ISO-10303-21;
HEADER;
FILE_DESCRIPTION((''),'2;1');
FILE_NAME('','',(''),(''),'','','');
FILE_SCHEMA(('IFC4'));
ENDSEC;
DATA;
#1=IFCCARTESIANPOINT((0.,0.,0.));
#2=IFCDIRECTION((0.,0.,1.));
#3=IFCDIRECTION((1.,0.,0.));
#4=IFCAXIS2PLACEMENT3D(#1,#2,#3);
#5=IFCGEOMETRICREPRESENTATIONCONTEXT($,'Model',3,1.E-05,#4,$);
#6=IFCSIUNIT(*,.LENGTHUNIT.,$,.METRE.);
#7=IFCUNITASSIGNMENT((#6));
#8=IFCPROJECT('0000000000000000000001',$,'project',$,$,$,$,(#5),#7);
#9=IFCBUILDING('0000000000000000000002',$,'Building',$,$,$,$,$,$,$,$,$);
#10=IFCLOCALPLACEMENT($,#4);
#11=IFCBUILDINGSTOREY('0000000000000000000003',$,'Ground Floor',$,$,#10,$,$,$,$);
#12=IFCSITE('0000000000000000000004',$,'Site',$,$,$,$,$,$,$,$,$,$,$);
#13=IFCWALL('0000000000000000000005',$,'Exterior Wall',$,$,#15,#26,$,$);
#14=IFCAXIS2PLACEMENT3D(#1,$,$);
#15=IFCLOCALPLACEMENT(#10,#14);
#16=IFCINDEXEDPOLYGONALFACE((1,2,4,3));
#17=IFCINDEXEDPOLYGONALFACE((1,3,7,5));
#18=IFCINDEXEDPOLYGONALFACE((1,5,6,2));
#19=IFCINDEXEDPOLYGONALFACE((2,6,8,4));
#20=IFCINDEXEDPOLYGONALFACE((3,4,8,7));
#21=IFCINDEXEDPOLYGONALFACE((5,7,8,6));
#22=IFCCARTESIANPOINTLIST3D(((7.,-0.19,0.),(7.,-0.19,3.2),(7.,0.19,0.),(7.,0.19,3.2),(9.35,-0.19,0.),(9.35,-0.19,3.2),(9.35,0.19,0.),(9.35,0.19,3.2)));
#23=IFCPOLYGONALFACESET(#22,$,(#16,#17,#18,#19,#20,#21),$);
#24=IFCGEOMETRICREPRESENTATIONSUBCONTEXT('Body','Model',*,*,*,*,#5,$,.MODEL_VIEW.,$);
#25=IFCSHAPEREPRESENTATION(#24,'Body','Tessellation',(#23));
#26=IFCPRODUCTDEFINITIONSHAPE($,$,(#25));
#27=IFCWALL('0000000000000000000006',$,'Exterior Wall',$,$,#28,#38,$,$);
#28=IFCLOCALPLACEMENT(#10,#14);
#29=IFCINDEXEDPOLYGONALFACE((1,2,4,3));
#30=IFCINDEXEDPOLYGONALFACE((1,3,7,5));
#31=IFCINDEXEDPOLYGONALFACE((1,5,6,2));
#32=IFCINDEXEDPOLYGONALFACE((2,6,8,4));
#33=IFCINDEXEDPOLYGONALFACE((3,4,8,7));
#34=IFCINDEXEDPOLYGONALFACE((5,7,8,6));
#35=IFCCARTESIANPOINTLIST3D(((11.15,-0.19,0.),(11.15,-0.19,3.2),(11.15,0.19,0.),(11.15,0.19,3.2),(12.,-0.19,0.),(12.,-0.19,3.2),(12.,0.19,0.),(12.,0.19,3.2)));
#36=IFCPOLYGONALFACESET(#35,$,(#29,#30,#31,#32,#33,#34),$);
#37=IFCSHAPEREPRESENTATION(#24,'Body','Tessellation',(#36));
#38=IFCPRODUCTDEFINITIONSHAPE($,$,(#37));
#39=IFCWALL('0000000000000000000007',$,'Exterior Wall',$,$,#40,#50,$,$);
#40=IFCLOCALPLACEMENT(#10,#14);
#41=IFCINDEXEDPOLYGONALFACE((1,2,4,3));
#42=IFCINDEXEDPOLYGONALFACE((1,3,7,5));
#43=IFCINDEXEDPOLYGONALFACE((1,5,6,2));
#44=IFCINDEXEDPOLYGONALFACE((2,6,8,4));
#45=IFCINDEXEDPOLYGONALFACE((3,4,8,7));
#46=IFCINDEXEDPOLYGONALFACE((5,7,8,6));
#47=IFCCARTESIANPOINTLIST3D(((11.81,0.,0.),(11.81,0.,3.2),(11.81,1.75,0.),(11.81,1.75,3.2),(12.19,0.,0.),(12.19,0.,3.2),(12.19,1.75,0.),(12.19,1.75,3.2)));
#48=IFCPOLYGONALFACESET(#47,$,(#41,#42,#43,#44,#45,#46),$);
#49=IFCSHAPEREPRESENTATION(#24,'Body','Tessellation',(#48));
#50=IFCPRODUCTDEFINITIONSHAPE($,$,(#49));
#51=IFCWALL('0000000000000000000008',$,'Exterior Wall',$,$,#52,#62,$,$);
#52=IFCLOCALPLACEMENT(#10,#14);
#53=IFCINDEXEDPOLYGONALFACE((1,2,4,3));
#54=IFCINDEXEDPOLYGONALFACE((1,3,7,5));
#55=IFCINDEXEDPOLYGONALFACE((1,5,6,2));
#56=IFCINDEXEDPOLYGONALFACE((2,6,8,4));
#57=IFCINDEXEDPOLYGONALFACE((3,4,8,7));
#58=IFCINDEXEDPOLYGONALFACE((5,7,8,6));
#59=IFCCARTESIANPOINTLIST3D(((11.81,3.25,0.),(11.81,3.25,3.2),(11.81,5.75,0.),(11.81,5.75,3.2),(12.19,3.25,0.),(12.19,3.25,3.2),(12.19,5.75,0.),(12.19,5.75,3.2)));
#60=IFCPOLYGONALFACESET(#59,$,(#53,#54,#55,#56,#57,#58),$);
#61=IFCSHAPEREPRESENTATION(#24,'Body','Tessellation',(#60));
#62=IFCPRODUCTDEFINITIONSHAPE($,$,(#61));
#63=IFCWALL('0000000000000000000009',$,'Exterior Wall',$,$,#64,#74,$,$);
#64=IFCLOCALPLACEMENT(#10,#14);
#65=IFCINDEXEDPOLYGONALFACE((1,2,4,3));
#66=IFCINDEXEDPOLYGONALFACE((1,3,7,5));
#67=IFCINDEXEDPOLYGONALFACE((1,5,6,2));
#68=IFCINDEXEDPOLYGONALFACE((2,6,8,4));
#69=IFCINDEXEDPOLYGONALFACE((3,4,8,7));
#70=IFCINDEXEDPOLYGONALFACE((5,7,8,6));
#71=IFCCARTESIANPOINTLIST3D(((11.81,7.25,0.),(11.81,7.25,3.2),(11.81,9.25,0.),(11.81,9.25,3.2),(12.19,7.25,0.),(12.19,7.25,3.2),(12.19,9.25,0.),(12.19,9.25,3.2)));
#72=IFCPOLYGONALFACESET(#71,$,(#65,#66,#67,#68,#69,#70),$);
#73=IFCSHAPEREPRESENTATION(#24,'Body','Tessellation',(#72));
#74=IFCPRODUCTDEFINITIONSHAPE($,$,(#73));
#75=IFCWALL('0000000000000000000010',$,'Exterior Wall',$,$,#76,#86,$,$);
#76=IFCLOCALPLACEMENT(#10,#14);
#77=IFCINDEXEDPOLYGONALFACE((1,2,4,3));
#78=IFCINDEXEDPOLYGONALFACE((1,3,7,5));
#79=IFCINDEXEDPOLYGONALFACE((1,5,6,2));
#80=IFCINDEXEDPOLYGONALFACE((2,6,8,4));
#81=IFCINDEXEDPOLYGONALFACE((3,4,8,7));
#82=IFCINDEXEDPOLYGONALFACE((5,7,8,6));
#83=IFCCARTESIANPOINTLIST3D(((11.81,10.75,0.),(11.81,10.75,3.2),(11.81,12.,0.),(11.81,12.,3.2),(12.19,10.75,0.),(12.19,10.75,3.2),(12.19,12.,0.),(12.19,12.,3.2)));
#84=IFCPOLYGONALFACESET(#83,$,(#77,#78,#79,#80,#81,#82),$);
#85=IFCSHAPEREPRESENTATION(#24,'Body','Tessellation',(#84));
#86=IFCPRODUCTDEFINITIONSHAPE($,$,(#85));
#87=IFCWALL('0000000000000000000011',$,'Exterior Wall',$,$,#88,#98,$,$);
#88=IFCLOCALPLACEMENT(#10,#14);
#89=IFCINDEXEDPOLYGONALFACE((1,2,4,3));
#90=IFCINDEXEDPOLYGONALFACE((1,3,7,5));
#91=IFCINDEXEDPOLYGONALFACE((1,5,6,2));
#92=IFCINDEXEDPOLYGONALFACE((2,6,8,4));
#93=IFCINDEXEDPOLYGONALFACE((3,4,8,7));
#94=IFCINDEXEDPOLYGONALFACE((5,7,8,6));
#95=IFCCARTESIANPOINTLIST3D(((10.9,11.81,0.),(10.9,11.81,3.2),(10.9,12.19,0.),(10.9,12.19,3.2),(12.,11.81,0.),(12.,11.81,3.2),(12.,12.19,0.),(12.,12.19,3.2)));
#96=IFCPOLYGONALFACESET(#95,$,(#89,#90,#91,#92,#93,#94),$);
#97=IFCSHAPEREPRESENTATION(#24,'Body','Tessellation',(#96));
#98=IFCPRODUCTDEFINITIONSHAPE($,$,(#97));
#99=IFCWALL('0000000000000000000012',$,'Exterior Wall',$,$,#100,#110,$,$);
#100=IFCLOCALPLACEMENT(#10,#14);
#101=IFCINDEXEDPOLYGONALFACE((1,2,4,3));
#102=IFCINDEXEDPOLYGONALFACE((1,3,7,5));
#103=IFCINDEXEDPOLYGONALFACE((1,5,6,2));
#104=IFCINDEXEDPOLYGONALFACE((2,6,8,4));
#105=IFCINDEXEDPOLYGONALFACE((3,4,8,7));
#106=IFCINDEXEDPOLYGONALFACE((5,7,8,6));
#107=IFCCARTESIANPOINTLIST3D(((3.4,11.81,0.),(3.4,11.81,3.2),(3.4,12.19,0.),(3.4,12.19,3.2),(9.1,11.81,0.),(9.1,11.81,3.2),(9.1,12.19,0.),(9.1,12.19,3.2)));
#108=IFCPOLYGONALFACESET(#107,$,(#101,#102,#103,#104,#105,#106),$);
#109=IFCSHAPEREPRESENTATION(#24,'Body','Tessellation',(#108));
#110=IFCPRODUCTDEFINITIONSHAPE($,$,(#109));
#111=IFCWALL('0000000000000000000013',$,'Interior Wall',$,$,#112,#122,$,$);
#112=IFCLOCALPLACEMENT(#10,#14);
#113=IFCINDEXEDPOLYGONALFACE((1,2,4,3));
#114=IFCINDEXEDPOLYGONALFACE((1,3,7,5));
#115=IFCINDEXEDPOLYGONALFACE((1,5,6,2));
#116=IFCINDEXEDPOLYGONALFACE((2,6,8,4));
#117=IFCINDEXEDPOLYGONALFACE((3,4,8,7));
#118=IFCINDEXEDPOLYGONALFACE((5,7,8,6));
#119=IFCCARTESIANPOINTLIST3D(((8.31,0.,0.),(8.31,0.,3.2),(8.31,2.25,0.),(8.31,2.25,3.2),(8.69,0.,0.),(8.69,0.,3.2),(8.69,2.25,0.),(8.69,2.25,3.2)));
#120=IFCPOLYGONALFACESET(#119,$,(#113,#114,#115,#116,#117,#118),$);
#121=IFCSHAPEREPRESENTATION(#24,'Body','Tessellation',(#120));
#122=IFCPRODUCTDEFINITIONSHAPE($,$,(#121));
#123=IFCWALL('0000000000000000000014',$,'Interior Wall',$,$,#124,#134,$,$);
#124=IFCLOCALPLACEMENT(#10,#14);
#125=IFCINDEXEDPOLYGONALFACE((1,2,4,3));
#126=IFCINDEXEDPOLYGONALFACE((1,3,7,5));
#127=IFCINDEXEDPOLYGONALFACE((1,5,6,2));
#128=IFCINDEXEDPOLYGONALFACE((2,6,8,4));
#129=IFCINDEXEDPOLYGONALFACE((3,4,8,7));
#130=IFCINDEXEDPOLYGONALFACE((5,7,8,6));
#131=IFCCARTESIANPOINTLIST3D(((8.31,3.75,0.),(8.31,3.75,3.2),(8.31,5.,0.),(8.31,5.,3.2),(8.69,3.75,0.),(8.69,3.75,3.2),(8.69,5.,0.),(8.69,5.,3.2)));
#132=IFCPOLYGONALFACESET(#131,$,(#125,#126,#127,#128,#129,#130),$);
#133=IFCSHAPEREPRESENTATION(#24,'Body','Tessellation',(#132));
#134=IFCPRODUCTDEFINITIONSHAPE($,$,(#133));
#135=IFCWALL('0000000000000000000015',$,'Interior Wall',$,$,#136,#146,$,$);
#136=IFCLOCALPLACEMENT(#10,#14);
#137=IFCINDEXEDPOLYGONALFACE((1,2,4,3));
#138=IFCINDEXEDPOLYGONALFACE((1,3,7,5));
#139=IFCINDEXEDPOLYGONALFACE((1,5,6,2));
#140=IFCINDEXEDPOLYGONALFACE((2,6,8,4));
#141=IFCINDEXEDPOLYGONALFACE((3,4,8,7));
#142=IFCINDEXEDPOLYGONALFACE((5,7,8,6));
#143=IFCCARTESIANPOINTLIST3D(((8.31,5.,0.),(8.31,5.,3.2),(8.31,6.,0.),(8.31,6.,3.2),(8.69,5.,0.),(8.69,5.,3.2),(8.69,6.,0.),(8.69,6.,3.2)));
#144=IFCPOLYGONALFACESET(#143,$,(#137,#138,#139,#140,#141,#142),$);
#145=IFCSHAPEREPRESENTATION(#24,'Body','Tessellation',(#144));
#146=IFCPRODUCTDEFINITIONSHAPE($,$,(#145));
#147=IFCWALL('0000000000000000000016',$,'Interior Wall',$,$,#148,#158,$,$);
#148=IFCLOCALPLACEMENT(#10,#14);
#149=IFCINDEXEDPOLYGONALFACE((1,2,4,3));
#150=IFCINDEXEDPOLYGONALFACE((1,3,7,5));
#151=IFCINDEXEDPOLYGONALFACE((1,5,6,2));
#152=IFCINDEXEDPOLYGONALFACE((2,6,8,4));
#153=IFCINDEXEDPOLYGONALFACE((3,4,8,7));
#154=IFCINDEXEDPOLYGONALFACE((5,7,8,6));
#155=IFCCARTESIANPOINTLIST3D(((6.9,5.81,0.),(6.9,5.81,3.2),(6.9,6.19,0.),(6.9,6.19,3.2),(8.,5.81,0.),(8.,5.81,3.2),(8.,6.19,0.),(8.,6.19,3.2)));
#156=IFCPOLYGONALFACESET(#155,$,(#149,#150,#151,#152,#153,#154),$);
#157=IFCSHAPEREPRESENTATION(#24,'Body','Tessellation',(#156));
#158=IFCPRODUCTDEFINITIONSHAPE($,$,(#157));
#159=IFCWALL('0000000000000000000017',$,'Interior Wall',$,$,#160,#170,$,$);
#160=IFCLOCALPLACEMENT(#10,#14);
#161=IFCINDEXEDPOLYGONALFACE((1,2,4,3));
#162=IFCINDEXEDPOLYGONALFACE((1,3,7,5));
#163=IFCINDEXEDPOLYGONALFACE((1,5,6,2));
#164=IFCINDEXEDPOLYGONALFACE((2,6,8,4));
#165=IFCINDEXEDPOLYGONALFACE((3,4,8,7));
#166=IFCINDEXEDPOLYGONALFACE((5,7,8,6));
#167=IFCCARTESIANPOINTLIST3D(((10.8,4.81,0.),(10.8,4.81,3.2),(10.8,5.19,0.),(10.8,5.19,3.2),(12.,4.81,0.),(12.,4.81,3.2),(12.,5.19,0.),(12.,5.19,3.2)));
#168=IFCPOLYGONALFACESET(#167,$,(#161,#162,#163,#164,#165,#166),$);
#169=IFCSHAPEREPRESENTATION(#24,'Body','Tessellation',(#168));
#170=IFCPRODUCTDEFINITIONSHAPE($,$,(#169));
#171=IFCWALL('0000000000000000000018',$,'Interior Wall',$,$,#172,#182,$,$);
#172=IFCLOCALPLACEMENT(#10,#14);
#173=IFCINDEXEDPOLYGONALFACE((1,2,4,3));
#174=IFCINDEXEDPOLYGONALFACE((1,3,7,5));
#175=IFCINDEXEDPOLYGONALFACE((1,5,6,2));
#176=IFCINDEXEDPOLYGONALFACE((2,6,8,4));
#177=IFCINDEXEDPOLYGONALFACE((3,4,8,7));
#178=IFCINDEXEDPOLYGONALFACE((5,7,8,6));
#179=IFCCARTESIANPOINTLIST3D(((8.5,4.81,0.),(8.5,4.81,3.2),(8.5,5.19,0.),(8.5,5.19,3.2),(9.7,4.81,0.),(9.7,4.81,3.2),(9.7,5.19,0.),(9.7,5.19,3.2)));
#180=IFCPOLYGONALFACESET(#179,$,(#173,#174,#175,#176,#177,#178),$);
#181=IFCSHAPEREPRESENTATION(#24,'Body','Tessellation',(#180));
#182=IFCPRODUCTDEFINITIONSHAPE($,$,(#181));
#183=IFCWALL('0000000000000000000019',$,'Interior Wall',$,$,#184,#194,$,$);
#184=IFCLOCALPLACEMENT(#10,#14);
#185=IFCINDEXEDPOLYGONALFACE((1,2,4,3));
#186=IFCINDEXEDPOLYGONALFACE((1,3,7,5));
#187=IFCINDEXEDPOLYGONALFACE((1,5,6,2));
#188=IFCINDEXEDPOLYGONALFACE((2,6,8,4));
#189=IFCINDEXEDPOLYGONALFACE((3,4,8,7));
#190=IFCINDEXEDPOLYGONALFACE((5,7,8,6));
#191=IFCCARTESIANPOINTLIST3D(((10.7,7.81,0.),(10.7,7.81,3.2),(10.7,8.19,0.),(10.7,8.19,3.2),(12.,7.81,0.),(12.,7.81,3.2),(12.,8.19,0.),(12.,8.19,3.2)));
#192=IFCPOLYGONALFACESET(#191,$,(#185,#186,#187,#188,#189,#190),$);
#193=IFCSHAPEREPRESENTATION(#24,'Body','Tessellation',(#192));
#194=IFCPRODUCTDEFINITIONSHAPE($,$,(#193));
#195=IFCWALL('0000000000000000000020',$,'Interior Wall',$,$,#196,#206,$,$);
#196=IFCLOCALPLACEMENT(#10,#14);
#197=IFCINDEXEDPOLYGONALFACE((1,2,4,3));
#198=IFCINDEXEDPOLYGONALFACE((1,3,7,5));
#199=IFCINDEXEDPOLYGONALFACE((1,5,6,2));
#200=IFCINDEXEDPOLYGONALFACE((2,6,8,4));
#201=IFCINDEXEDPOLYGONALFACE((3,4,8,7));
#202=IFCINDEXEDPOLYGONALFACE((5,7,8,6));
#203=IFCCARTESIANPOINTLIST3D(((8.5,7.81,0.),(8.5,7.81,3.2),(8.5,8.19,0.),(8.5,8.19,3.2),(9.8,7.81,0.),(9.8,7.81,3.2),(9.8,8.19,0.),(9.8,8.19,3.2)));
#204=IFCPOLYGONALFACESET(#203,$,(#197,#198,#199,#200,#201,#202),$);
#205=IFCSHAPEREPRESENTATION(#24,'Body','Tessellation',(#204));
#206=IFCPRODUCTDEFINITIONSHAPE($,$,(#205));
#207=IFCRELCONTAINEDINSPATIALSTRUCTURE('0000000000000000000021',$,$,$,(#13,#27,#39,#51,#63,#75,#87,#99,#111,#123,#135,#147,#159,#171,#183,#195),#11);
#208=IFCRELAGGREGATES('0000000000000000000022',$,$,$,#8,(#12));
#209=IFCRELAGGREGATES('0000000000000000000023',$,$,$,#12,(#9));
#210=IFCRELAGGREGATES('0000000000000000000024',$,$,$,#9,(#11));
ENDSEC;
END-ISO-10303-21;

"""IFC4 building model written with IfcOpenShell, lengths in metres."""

from ifc_helpers import new_model, si_unit, frame, origin_with_axes, place, context, subcontext, project, spatial, indexed_curve, outline, extrude, element, save


model = new_model("IFC4")

# Units and contexts
model_context = context("Model", 3, precision=1e-05, world=origin_with_axes())
body_context = subcontext(model_context, "Body", "Model", "MODEL_VIEW")
ifc_project = project(units=[si_unit("LENGTHUNIT", "METRE")], contexts=[model_context])

# Site, building, storey
site = spatial("IfcSite", under=ifc_project, Name="Site")
building = spatial("IfcBuilding", under=site, Name="Building")
storey_placement = place(None, origin_with_axes())
storey = spatial("IfcBuildingStorey", under=building, at=storey_placement, Name="Ground Floor")

# Walls
wall_1_placement = place(storey_placement, frame((7.0, 0.0, 0.0), z_axis=(0.0, 0.0, 1.0), x_axis=(1.0, 0.0, 0.0)))
element("IfcWall", 1, at=wall_1_placement, inside=storey, Name="Exterior Wall", context=body_context, shape_type="SweptSolid", body=[
    extrude(outline(indexed_curve([(0.0, 0.0), (0.0, 0.38), (2.35, 0.38), (2.35, 0.0), (0.0, 0.0)], self_intersect=False)), frame((0.0, -0.19, 0.0), z_axis=(0.0, 0.0, 1.0), x_axis=(1.0, 0.0, 0.0)), (0.0, 0.0, 1.0), 3.2),
])
wall_2_placement = place(storey_placement, frame((11.15, 0.0, 0.0), z_axis=(0.0, 0.0, 1.0), x_axis=(1.0, 0.0, 0.0)))
element("IfcWall", 2, at=wall_2_placement, inside=storey, Name="Exterior Wall", context=body_context, shape_type="SweptSolid", body=[
    extrude(outline(indexed_curve([(0.0, 0.0), (0.0, 0.38), (0.85, 0.38), (0.85, 0.0), (0.0, 0.0)], self_intersect=False)), frame((0.0, -0.19, 0.0), z_axis=(0.0, 0.0, 1.0), x_axis=(1.0, 0.0, 0.0)), (0.0, 0.0, 1.0), 3.2),
])
wall_3_placement = place(storey_placement, frame((12.0, 0.0, 0.0), z_axis=(0.0, 0.0, 1.0), x_axis=(0.0, 1.0, 0.0)))
element("IfcWall", 3, at=wall_3_placement, inside=storey, Name="Exterior Wall", context=body_context, shape_type="SweptSolid", body=[
    extrude(outline(indexed_curve([(0.0, 0.0), (0.0, 0.38), (1.75, 0.38), (1.75, 0.0), (0.0, 0.0)], self_intersect=False)), frame((0.0, -0.19, 0.0), z_axis=(0.0, 0.0, 1.0), x_axis=(1.0, 0.0, 0.0)), (0.0, 0.0, 1.0), 3.2),
])
wall_4_placement = place(storey_placement, frame((12.0, 3.25, 0.0), z_axis=(0.0, 0.0, 1.0), x_axis=(0.0, 1.0, 0.0)))
element("IfcWall", 4, at=wall_4_placement, inside=storey, Name="Exterior Wall", context=body_context, shape_type="SweptSolid", body=[
    extrude(outline(indexed_curve([(0.0, 0.0), (0.0, 0.38), (2.5, 0.38), (2.5, 0.0), (0.0, 0.0)], self_intersect=False)), frame((0.0, -0.19, 0.0), z_axis=(0.0, 0.0, 1.0), x_axis=(1.0, 0.0, 0.0)), (0.0, 0.0, 1.0), 3.2),
])
wall_5_placement = place(storey_placement, frame((12.0, 7.25, 0.0), z_axis=(0.0, 0.0, 1.0), x_axis=(0.0, 1.0, 0.0)))
element("IfcWall", 5, at=wall_5_placement, inside=storey, Name="Exterior Wall", context=body_context, shape_type="SweptSolid", body=[
    extrude(outline(indexed_curve([(0.0, 0.0), (0.0, 0.38), (2.0, 0.38), (2.0, 0.0), (0.0, 0.0)], self_intersect=False)), frame((0.0, -0.19, 0.0), z_axis=(0.0, 0.0, 1.0), x_axis=(1.0, 0.0, 0.0)), (0.0, 0.0, 1.0), 3.2),
])
wall_6_placement = place(storey_placement, frame((12.0, 10.75, 0.0), z_axis=(0.0, 0.0, 1.0), x_axis=(0.0, 1.0, 0.0)))
element("IfcWall", 6, at=wall_6_placement, inside=storey, Name="Exterior Wall", context=body_context, shape_type="SweptSolid", body=[
    extrude(outline(indexed_curve([(0.0, 0.0), (0.0, 0.38), (1.25, 0.38), (1.25, 0.0), (0.0, 0.0)], self_intersect=False)), frame((0.0, -0.19, 0.0), z_axis=(0.0, 0.0, 1.0), x_axis=(1.0, 0.0, 0.0)), (0.0, 0.0, 1.0), 3.2),
])
wall_7_placement = place(storey_placement, frame((12.0, 12.0, 0.0), z_axis=(0.0, 0.0, 1.0), x_axis=(-1.0, 0.0, 0.0)))
element("IfcWall", 7, at=wall_7_placement, inside=storey, Name="Exterior Wall", context=body_context, shape_type="SweptSolid", body=[
    extrude(outline(indexed_curve([(0.0, 0.0), (0.0, 0.38), (1.1, 0.38), (1.1, 0.0), (0.0, 0.0)], self_intersect=False)), frame((0.0, -0.19, 0.0), z_axis=(0.0, 0.0, 1.0), x_axis=(1.0, 0.0, 0.0)), (0.0, 0.0, 1.0), 3.2),
])
wall_8_placement = place(storey_placement, frame((9.1, 12.0, 0.0), z_axis=(0.0, 0.0, 1.0), x_axis=(-1.0, 0.0, 0.0)))
element("IfcWall", 8, at=wall_8_placement, inside=storey, Name="Exterior Wall", context=body_context, shape_type="SweptSolid", body=[
    extrude(outline(indexed_curve([(0.0, 0.0), (0.0, 0.38), (5.7, 0.38), (5.7, 0.0), (0.0, 0.0)], self_intersect=False)), frame((0.0, -0.19, 0.0), z_axis=(0.0, 0.0, 1.0), x_axis=(1.0, 0.0, 0.0)), (0.0, 0.0, 1.0), 3.2),
])
wall_9_placement = place(storey_placement, frame((8.5, 0.0, 0.0), z_axis=(0.0, 0.0, 1.0), x_axis=(0.0, 1.0, 0.0)))
element("IfcWall", 9, at=wall_9_placement, inside=storey, Name="Interior Wall", context=body_context, shape_type="SweptSolid", body=[
    extrude(outline(indexed_curve([(0.0, 0.0), (0.0, 0.38), (2.25, 0.38), (2.25, 0.0), (0.0, 0.0)], self_intersect=False)), frame((0.0, -0.19, 0.0), z_axis=(0.0, 0.0, 1.0), x_axis=(1.0, 0.0, 0.0)), (0.0, 0.0, 1.0), 3.2),
])
wall_10_placement = place(storey_placement, frame((8.5, 3.75, 0.0), z_axis=(0.0, 0.0, 1.0), x_axis=(0.0, 1.0, 0.0)))
element("IfcWall", 10, at=wall_10_placement, inside=storey, Name="Interior Wall", context=body_context, shape_type="SweptSolid", body=[
    extrude(outline(indexed_curve([(0.0, 0.0), (0.0, 0.38), (1.25, 0.38), (1.25, 0.0), (0.0, 0.0)], self_intersect=False)), frame((0.0, -0.19, 0.0), z_axis=(0.0, 0.0, 1.0), x_axis=(1.0, 0.0, 0.0)), (0.0, 0.0, 1.0), 3.2),
])
wall_11_placement = place(storey_placement, frame((8.5, 5.0, 0.0), z_axis=(0.0, 0.0, 1.0), x_axis=(0.0, 1.0, 0.0)))
element("IfcWall", 11, at=wall_11_placement, inside=storey, Name="Interior Wall", context=body_context, shape_type="SweptSolid", body=[
    extrude(outline(indexed_curve([(0.0, 0.0), (0.0, 0.38), (1.0, 0.38), (1.0, 0.0), (0.0, 0.0)], self_intersect=False)), frame((0.0, -0.19, 0.0), z_axis=(0.0, 0.0, 1.0), x_axis=(1.0, 0.0, 0.0)), (0.0, 0.0, 1.0), 3.2),
])
wall_12_placement = place(storey_placement, frame((8.0, 6.0, 0.0), z_axis=(0.0, 0.0, 1.0), x_axis=(-1.0, 0.0, 0.0)))
element("IfcWall", 12, at=wall_12_placement, inside=storey, Name="Interior Wall", context=body_context, shape_type="SweptSolid", body=[
    extrude(outline(indexed_curve([(0.0, 0.0), (0.0, 0.38), (1.1, 0.38), (1.1, 0.0), (0.0, 0.0)], self_intersect=False)), frame((0.0, -0.19, 0.0), z_axis=(0.0, 0.0, 1.0), x_axis=(1.0, 0.0, 0.0)), (0.0, 0.0, 1.0), 3.2),
])
for number, where, z_axis, x_axis, name in (
    (13, (12.0, 5.0, 0.0), (0.0, 0.0, 1.0), (-1.0, 0.0, 0.0), "Interior Wall"),
    (14, (9.7, 5.0, 0.0), (0.0, 0.0, 1.0), (-1.0, 0.0, 0.0), "Interior Wall"),
):
    element("IfcWall", number, at=place(storey_placement, frame(where, z_axis=z_axis, x_axis=x_axis)), inside=storey, Name=name, context=body_context, shape_type="SweptSolid", body=[
        extrude(outline(indexed_curve([(0.0, 0.0), (0.0, 0.38), (1.2, 0.38), (1.2, 0.0), (0.0, 0.0)], self_intersect=False)), frame((0.0, -0.19, 0.0), z_axis=(0.0, 0.0, 1.0), x_axis=(1.0, 0.0, 0.0)), (0.0, 0.0, 1.0), 3.2),
    ])
for number, where, z_axis, x_axis, name in (
    (15, (12.0, 8.0, 0.0), (0.0, 0.0, 1.0), (-1.0, 0.0, 0.0), "Interior Wall"),
    (16, (9.8, 8.0, 0.0), (0.0, 0.0, 1.0), (-1.0, 0.0, 0.0), "Interior Wall"),
):
    element("IfcWall", number, at=place(storey_placement, frame(where, z_axis=z_axis, x_axis=x_axis)), inside=storey, Name=name, context=body_context, shape_type="SweptSolid", body=[
        extrude(outline(indexed_curve([(0.0, 0.0), (0.0, 0.38), (1.3, 0.38), (1.3, 0.0), (0.0, 0.0)], self_intersect=False)), frame((0.0, -0.19, 0.0), z_axis=(0.0, 0.0, 1.0), x_axis=(1.0, 0.0, 0.0)), (0.0, 0.0, 1.0), 3.2),
    ])

save(model, "model.ifc")
